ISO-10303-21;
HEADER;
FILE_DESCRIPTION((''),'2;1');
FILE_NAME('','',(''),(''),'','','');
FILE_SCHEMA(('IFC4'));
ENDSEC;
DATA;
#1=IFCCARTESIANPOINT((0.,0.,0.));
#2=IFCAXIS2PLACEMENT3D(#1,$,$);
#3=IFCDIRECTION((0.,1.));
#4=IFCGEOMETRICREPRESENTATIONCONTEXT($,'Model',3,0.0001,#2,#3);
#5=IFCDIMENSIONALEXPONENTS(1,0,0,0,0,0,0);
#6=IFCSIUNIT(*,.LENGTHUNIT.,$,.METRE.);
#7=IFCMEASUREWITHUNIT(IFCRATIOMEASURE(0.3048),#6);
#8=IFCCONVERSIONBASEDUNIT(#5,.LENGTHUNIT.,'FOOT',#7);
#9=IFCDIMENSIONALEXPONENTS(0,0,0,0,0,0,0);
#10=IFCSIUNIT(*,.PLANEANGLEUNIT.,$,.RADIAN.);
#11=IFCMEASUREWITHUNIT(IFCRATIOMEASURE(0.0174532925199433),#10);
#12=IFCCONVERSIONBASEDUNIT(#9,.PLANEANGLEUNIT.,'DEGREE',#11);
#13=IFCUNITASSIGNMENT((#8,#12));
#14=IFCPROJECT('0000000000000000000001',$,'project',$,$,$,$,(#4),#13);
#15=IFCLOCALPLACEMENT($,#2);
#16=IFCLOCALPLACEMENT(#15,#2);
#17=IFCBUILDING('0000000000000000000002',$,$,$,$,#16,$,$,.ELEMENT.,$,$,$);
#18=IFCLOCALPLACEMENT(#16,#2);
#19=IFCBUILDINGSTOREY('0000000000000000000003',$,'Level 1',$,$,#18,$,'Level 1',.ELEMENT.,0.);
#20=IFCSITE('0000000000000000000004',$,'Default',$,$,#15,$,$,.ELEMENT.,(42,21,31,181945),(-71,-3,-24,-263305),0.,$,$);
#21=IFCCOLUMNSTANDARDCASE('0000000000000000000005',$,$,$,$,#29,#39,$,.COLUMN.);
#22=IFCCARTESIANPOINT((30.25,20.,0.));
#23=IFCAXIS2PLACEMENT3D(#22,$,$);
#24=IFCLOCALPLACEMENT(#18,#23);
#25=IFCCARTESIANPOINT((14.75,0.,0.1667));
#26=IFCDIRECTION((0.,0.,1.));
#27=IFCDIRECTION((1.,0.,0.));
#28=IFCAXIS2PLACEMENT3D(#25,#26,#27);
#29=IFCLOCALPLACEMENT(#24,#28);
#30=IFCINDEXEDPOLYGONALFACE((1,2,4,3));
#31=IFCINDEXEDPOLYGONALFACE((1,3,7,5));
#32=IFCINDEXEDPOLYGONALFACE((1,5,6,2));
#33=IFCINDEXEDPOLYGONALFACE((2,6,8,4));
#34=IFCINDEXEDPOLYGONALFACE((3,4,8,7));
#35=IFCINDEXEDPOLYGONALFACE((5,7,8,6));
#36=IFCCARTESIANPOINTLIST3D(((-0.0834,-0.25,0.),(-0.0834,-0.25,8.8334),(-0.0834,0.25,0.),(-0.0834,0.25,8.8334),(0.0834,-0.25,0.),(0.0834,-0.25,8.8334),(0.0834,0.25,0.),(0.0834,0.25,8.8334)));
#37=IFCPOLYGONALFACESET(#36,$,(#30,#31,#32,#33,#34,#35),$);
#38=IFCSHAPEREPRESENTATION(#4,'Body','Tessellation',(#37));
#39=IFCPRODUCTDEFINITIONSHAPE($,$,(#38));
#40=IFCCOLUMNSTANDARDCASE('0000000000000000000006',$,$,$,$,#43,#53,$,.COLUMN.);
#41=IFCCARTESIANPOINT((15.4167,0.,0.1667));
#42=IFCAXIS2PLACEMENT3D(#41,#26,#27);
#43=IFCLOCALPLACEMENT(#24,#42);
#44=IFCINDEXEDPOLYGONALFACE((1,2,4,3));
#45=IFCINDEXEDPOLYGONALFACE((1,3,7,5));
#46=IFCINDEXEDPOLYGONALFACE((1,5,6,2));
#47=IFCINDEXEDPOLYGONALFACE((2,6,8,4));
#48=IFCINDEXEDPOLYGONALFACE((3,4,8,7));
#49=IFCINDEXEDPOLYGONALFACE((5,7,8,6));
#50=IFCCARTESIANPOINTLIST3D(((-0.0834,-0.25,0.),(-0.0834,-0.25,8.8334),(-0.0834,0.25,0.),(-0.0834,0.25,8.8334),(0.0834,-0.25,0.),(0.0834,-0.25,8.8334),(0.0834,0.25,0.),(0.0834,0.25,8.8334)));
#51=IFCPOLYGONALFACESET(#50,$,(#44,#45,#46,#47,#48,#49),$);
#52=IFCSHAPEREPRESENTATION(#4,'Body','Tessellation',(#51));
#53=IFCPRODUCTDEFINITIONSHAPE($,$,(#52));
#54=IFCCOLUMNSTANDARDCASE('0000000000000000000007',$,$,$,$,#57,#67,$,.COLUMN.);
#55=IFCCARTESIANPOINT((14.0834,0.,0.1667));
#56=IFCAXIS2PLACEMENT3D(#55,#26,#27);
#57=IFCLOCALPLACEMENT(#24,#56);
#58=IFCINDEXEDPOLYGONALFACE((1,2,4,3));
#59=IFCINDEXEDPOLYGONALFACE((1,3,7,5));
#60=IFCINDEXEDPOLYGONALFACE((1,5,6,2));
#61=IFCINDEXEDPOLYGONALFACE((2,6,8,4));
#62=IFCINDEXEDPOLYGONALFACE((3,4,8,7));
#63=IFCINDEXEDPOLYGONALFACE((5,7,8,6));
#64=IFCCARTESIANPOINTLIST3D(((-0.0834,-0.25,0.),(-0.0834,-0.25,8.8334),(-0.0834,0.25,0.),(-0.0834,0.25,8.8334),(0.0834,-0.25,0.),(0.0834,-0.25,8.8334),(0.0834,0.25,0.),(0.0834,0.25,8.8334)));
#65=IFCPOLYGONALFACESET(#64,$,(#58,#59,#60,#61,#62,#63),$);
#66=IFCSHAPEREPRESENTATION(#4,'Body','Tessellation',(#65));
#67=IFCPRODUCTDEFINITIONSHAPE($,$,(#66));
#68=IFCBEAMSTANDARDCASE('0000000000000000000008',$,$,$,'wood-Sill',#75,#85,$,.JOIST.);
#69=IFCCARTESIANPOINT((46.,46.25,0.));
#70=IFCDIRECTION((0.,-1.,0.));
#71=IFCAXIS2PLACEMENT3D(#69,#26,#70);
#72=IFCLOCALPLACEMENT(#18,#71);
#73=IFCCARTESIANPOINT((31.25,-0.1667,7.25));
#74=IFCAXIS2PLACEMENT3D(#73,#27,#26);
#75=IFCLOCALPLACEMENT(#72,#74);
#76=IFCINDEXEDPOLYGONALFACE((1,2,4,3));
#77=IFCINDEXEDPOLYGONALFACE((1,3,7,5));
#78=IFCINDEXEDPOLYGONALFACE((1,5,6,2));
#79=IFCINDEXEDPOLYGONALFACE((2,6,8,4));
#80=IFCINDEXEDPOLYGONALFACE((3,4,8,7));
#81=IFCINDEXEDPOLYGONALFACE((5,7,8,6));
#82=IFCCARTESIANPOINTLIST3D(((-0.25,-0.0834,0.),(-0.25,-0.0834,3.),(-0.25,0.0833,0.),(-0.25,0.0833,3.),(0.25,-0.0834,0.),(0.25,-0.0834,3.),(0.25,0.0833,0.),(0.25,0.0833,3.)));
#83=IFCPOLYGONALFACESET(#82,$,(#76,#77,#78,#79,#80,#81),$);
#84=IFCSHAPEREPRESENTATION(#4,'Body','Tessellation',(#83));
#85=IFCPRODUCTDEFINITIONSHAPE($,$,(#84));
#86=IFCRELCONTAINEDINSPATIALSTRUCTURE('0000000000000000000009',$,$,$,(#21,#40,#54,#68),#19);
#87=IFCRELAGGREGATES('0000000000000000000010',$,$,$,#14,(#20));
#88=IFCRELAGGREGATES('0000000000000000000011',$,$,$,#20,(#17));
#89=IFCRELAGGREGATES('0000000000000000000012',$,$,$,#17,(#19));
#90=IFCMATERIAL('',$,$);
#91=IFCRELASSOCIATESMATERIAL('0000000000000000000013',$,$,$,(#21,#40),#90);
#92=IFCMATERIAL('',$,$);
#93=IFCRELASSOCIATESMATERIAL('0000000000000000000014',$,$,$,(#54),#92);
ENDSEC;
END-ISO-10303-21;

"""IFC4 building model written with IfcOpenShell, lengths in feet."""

from ifc_helpers import new_model, entity, si_unit, converted_unit, direction, frame, origin, origin_with_axes, place, context, project, spatial, rectangle, extrude, material, element, save


model = new_model("IFC4")

# Units and contexts
model_context = context("Model", 3, precision=0.0001, world=origin(), true_north=direction((0.0, 1.0)))
ifc_project = project(units=[converted_unit("LENGTHUNIT", "FOOT", entity("IfcRatioMeasure", 0.3048), si_unit("LENGTHUNIT", "METRE"), dimensions=[1, 0, 0, 0, 0, 0, 0]), converted_unit("PLANEANGLEUNIT", "DEGREE", entity("IfcRatioMeasure", 0.0174532925199433), si_unit("PLANEANGLEUNIT", "RADIAN"), dimensions=[0, 0, 0, 0, 0, 0, 0])], contexts=[model_context])

# Site, building, storey
site_placement = place(None, origin())
site = spatial("IfcSite", under=ifc_project, at=site_placement, Name="Default", CompositionType="ELEMENT", RefLatitude=(42, 21, 31, 181945), RefLongitude=(-71, -3, -24, -263305), RefElevation=0.0)
building_placement = place(site_placement, origin())
building = spatial("IfcBuilding", under=site, at=building_placement, CompositionType="ELEMENT")
storey_placement = place(building_placement, origin())
storey = spatial("IfcBuildingStorey", under=building, at=storey_placement, Name="Level 1", LongName="Level 1", CompositionType="ELEMENT", Elevation=0.0)

# Columns
placement_1 = place(storey_placement, frame((46.0, 46.25, 0.0), z_axis=(0.0, 0.0, 1.0), x_axis=(0.0, -1.0, 0.0)))
ifc_material_1 = material(Name="")
placement_2 = place(storey_placement, frame((30.25, 20.0, 0.0)))
for number, where, z_axis, x_axis in (
    (1, (14.75, 0.0, 0.1667), (0.0, 0.0, 1.0), (1.0, 0.0, 0.0)),
    (2, (15.4167, 0.0, 0.1667), (0.0, 0.0, 1.0), (1.0, 0.0, 0.0)),
):
    element("IfcColumnStandardCase", number, at=place(placement_2, frame(where, z_axis=z_axis, x_axis=x_axis)), inside=storey, material=ifc_material_1, PredefinedType="COLUMN", context=model_context, shape_type="SweptSolid", body=[
        extrude(rectangle(XDim=0.1667, YDim=0.5), origin(), (0.0, 0.0, 1.0), 8.8334),
    ])
ifc_material_2 = material(Name="")
for number, where, z_axis, x_axis in (
    (3, (14.0834, 0.0, 0.1667), (0.0, 0.0, 1.0), (1.0, 0.0, 0.0)),
):
    element("IfcColumnStandardCase", number, at=place(placement_2, frame(where, z_axis=z_axis, x_axis=x_axis)), inside=storey, material=ifc_material_2, PredefinedType="COLUMN", context=model_context, shape_type="SweptSolid", body=[
        extrude(rectangle(XDim=0.1667, YDim=0.5), origin(), (0.0, 0.0, 1.0), 8.8334),
    ])

# Beam
for number, where, z_axis, x_axis in (
    (4, (31.25, -0.1667, 7.25), (1.0, 0.0, 0.0), (0.0, 0.0, 1.0)),
):
    element("IfcBeamStandardCase", number, at=place(placement_1, frame(where, z_axis=z_axis, x_axis=x_axis)), inside=storey, ObjectType="wood-Sill", PredefinedType="JOIST", context=model_context, shape_type="SweptSolid", body=[
        extrude(rectangle(XDim=0.5, YDim=0.1667), origin_with_axes(), (0.0, 0.0, 1.0), 3.0),
    ])

save(model, "model.ifc")
